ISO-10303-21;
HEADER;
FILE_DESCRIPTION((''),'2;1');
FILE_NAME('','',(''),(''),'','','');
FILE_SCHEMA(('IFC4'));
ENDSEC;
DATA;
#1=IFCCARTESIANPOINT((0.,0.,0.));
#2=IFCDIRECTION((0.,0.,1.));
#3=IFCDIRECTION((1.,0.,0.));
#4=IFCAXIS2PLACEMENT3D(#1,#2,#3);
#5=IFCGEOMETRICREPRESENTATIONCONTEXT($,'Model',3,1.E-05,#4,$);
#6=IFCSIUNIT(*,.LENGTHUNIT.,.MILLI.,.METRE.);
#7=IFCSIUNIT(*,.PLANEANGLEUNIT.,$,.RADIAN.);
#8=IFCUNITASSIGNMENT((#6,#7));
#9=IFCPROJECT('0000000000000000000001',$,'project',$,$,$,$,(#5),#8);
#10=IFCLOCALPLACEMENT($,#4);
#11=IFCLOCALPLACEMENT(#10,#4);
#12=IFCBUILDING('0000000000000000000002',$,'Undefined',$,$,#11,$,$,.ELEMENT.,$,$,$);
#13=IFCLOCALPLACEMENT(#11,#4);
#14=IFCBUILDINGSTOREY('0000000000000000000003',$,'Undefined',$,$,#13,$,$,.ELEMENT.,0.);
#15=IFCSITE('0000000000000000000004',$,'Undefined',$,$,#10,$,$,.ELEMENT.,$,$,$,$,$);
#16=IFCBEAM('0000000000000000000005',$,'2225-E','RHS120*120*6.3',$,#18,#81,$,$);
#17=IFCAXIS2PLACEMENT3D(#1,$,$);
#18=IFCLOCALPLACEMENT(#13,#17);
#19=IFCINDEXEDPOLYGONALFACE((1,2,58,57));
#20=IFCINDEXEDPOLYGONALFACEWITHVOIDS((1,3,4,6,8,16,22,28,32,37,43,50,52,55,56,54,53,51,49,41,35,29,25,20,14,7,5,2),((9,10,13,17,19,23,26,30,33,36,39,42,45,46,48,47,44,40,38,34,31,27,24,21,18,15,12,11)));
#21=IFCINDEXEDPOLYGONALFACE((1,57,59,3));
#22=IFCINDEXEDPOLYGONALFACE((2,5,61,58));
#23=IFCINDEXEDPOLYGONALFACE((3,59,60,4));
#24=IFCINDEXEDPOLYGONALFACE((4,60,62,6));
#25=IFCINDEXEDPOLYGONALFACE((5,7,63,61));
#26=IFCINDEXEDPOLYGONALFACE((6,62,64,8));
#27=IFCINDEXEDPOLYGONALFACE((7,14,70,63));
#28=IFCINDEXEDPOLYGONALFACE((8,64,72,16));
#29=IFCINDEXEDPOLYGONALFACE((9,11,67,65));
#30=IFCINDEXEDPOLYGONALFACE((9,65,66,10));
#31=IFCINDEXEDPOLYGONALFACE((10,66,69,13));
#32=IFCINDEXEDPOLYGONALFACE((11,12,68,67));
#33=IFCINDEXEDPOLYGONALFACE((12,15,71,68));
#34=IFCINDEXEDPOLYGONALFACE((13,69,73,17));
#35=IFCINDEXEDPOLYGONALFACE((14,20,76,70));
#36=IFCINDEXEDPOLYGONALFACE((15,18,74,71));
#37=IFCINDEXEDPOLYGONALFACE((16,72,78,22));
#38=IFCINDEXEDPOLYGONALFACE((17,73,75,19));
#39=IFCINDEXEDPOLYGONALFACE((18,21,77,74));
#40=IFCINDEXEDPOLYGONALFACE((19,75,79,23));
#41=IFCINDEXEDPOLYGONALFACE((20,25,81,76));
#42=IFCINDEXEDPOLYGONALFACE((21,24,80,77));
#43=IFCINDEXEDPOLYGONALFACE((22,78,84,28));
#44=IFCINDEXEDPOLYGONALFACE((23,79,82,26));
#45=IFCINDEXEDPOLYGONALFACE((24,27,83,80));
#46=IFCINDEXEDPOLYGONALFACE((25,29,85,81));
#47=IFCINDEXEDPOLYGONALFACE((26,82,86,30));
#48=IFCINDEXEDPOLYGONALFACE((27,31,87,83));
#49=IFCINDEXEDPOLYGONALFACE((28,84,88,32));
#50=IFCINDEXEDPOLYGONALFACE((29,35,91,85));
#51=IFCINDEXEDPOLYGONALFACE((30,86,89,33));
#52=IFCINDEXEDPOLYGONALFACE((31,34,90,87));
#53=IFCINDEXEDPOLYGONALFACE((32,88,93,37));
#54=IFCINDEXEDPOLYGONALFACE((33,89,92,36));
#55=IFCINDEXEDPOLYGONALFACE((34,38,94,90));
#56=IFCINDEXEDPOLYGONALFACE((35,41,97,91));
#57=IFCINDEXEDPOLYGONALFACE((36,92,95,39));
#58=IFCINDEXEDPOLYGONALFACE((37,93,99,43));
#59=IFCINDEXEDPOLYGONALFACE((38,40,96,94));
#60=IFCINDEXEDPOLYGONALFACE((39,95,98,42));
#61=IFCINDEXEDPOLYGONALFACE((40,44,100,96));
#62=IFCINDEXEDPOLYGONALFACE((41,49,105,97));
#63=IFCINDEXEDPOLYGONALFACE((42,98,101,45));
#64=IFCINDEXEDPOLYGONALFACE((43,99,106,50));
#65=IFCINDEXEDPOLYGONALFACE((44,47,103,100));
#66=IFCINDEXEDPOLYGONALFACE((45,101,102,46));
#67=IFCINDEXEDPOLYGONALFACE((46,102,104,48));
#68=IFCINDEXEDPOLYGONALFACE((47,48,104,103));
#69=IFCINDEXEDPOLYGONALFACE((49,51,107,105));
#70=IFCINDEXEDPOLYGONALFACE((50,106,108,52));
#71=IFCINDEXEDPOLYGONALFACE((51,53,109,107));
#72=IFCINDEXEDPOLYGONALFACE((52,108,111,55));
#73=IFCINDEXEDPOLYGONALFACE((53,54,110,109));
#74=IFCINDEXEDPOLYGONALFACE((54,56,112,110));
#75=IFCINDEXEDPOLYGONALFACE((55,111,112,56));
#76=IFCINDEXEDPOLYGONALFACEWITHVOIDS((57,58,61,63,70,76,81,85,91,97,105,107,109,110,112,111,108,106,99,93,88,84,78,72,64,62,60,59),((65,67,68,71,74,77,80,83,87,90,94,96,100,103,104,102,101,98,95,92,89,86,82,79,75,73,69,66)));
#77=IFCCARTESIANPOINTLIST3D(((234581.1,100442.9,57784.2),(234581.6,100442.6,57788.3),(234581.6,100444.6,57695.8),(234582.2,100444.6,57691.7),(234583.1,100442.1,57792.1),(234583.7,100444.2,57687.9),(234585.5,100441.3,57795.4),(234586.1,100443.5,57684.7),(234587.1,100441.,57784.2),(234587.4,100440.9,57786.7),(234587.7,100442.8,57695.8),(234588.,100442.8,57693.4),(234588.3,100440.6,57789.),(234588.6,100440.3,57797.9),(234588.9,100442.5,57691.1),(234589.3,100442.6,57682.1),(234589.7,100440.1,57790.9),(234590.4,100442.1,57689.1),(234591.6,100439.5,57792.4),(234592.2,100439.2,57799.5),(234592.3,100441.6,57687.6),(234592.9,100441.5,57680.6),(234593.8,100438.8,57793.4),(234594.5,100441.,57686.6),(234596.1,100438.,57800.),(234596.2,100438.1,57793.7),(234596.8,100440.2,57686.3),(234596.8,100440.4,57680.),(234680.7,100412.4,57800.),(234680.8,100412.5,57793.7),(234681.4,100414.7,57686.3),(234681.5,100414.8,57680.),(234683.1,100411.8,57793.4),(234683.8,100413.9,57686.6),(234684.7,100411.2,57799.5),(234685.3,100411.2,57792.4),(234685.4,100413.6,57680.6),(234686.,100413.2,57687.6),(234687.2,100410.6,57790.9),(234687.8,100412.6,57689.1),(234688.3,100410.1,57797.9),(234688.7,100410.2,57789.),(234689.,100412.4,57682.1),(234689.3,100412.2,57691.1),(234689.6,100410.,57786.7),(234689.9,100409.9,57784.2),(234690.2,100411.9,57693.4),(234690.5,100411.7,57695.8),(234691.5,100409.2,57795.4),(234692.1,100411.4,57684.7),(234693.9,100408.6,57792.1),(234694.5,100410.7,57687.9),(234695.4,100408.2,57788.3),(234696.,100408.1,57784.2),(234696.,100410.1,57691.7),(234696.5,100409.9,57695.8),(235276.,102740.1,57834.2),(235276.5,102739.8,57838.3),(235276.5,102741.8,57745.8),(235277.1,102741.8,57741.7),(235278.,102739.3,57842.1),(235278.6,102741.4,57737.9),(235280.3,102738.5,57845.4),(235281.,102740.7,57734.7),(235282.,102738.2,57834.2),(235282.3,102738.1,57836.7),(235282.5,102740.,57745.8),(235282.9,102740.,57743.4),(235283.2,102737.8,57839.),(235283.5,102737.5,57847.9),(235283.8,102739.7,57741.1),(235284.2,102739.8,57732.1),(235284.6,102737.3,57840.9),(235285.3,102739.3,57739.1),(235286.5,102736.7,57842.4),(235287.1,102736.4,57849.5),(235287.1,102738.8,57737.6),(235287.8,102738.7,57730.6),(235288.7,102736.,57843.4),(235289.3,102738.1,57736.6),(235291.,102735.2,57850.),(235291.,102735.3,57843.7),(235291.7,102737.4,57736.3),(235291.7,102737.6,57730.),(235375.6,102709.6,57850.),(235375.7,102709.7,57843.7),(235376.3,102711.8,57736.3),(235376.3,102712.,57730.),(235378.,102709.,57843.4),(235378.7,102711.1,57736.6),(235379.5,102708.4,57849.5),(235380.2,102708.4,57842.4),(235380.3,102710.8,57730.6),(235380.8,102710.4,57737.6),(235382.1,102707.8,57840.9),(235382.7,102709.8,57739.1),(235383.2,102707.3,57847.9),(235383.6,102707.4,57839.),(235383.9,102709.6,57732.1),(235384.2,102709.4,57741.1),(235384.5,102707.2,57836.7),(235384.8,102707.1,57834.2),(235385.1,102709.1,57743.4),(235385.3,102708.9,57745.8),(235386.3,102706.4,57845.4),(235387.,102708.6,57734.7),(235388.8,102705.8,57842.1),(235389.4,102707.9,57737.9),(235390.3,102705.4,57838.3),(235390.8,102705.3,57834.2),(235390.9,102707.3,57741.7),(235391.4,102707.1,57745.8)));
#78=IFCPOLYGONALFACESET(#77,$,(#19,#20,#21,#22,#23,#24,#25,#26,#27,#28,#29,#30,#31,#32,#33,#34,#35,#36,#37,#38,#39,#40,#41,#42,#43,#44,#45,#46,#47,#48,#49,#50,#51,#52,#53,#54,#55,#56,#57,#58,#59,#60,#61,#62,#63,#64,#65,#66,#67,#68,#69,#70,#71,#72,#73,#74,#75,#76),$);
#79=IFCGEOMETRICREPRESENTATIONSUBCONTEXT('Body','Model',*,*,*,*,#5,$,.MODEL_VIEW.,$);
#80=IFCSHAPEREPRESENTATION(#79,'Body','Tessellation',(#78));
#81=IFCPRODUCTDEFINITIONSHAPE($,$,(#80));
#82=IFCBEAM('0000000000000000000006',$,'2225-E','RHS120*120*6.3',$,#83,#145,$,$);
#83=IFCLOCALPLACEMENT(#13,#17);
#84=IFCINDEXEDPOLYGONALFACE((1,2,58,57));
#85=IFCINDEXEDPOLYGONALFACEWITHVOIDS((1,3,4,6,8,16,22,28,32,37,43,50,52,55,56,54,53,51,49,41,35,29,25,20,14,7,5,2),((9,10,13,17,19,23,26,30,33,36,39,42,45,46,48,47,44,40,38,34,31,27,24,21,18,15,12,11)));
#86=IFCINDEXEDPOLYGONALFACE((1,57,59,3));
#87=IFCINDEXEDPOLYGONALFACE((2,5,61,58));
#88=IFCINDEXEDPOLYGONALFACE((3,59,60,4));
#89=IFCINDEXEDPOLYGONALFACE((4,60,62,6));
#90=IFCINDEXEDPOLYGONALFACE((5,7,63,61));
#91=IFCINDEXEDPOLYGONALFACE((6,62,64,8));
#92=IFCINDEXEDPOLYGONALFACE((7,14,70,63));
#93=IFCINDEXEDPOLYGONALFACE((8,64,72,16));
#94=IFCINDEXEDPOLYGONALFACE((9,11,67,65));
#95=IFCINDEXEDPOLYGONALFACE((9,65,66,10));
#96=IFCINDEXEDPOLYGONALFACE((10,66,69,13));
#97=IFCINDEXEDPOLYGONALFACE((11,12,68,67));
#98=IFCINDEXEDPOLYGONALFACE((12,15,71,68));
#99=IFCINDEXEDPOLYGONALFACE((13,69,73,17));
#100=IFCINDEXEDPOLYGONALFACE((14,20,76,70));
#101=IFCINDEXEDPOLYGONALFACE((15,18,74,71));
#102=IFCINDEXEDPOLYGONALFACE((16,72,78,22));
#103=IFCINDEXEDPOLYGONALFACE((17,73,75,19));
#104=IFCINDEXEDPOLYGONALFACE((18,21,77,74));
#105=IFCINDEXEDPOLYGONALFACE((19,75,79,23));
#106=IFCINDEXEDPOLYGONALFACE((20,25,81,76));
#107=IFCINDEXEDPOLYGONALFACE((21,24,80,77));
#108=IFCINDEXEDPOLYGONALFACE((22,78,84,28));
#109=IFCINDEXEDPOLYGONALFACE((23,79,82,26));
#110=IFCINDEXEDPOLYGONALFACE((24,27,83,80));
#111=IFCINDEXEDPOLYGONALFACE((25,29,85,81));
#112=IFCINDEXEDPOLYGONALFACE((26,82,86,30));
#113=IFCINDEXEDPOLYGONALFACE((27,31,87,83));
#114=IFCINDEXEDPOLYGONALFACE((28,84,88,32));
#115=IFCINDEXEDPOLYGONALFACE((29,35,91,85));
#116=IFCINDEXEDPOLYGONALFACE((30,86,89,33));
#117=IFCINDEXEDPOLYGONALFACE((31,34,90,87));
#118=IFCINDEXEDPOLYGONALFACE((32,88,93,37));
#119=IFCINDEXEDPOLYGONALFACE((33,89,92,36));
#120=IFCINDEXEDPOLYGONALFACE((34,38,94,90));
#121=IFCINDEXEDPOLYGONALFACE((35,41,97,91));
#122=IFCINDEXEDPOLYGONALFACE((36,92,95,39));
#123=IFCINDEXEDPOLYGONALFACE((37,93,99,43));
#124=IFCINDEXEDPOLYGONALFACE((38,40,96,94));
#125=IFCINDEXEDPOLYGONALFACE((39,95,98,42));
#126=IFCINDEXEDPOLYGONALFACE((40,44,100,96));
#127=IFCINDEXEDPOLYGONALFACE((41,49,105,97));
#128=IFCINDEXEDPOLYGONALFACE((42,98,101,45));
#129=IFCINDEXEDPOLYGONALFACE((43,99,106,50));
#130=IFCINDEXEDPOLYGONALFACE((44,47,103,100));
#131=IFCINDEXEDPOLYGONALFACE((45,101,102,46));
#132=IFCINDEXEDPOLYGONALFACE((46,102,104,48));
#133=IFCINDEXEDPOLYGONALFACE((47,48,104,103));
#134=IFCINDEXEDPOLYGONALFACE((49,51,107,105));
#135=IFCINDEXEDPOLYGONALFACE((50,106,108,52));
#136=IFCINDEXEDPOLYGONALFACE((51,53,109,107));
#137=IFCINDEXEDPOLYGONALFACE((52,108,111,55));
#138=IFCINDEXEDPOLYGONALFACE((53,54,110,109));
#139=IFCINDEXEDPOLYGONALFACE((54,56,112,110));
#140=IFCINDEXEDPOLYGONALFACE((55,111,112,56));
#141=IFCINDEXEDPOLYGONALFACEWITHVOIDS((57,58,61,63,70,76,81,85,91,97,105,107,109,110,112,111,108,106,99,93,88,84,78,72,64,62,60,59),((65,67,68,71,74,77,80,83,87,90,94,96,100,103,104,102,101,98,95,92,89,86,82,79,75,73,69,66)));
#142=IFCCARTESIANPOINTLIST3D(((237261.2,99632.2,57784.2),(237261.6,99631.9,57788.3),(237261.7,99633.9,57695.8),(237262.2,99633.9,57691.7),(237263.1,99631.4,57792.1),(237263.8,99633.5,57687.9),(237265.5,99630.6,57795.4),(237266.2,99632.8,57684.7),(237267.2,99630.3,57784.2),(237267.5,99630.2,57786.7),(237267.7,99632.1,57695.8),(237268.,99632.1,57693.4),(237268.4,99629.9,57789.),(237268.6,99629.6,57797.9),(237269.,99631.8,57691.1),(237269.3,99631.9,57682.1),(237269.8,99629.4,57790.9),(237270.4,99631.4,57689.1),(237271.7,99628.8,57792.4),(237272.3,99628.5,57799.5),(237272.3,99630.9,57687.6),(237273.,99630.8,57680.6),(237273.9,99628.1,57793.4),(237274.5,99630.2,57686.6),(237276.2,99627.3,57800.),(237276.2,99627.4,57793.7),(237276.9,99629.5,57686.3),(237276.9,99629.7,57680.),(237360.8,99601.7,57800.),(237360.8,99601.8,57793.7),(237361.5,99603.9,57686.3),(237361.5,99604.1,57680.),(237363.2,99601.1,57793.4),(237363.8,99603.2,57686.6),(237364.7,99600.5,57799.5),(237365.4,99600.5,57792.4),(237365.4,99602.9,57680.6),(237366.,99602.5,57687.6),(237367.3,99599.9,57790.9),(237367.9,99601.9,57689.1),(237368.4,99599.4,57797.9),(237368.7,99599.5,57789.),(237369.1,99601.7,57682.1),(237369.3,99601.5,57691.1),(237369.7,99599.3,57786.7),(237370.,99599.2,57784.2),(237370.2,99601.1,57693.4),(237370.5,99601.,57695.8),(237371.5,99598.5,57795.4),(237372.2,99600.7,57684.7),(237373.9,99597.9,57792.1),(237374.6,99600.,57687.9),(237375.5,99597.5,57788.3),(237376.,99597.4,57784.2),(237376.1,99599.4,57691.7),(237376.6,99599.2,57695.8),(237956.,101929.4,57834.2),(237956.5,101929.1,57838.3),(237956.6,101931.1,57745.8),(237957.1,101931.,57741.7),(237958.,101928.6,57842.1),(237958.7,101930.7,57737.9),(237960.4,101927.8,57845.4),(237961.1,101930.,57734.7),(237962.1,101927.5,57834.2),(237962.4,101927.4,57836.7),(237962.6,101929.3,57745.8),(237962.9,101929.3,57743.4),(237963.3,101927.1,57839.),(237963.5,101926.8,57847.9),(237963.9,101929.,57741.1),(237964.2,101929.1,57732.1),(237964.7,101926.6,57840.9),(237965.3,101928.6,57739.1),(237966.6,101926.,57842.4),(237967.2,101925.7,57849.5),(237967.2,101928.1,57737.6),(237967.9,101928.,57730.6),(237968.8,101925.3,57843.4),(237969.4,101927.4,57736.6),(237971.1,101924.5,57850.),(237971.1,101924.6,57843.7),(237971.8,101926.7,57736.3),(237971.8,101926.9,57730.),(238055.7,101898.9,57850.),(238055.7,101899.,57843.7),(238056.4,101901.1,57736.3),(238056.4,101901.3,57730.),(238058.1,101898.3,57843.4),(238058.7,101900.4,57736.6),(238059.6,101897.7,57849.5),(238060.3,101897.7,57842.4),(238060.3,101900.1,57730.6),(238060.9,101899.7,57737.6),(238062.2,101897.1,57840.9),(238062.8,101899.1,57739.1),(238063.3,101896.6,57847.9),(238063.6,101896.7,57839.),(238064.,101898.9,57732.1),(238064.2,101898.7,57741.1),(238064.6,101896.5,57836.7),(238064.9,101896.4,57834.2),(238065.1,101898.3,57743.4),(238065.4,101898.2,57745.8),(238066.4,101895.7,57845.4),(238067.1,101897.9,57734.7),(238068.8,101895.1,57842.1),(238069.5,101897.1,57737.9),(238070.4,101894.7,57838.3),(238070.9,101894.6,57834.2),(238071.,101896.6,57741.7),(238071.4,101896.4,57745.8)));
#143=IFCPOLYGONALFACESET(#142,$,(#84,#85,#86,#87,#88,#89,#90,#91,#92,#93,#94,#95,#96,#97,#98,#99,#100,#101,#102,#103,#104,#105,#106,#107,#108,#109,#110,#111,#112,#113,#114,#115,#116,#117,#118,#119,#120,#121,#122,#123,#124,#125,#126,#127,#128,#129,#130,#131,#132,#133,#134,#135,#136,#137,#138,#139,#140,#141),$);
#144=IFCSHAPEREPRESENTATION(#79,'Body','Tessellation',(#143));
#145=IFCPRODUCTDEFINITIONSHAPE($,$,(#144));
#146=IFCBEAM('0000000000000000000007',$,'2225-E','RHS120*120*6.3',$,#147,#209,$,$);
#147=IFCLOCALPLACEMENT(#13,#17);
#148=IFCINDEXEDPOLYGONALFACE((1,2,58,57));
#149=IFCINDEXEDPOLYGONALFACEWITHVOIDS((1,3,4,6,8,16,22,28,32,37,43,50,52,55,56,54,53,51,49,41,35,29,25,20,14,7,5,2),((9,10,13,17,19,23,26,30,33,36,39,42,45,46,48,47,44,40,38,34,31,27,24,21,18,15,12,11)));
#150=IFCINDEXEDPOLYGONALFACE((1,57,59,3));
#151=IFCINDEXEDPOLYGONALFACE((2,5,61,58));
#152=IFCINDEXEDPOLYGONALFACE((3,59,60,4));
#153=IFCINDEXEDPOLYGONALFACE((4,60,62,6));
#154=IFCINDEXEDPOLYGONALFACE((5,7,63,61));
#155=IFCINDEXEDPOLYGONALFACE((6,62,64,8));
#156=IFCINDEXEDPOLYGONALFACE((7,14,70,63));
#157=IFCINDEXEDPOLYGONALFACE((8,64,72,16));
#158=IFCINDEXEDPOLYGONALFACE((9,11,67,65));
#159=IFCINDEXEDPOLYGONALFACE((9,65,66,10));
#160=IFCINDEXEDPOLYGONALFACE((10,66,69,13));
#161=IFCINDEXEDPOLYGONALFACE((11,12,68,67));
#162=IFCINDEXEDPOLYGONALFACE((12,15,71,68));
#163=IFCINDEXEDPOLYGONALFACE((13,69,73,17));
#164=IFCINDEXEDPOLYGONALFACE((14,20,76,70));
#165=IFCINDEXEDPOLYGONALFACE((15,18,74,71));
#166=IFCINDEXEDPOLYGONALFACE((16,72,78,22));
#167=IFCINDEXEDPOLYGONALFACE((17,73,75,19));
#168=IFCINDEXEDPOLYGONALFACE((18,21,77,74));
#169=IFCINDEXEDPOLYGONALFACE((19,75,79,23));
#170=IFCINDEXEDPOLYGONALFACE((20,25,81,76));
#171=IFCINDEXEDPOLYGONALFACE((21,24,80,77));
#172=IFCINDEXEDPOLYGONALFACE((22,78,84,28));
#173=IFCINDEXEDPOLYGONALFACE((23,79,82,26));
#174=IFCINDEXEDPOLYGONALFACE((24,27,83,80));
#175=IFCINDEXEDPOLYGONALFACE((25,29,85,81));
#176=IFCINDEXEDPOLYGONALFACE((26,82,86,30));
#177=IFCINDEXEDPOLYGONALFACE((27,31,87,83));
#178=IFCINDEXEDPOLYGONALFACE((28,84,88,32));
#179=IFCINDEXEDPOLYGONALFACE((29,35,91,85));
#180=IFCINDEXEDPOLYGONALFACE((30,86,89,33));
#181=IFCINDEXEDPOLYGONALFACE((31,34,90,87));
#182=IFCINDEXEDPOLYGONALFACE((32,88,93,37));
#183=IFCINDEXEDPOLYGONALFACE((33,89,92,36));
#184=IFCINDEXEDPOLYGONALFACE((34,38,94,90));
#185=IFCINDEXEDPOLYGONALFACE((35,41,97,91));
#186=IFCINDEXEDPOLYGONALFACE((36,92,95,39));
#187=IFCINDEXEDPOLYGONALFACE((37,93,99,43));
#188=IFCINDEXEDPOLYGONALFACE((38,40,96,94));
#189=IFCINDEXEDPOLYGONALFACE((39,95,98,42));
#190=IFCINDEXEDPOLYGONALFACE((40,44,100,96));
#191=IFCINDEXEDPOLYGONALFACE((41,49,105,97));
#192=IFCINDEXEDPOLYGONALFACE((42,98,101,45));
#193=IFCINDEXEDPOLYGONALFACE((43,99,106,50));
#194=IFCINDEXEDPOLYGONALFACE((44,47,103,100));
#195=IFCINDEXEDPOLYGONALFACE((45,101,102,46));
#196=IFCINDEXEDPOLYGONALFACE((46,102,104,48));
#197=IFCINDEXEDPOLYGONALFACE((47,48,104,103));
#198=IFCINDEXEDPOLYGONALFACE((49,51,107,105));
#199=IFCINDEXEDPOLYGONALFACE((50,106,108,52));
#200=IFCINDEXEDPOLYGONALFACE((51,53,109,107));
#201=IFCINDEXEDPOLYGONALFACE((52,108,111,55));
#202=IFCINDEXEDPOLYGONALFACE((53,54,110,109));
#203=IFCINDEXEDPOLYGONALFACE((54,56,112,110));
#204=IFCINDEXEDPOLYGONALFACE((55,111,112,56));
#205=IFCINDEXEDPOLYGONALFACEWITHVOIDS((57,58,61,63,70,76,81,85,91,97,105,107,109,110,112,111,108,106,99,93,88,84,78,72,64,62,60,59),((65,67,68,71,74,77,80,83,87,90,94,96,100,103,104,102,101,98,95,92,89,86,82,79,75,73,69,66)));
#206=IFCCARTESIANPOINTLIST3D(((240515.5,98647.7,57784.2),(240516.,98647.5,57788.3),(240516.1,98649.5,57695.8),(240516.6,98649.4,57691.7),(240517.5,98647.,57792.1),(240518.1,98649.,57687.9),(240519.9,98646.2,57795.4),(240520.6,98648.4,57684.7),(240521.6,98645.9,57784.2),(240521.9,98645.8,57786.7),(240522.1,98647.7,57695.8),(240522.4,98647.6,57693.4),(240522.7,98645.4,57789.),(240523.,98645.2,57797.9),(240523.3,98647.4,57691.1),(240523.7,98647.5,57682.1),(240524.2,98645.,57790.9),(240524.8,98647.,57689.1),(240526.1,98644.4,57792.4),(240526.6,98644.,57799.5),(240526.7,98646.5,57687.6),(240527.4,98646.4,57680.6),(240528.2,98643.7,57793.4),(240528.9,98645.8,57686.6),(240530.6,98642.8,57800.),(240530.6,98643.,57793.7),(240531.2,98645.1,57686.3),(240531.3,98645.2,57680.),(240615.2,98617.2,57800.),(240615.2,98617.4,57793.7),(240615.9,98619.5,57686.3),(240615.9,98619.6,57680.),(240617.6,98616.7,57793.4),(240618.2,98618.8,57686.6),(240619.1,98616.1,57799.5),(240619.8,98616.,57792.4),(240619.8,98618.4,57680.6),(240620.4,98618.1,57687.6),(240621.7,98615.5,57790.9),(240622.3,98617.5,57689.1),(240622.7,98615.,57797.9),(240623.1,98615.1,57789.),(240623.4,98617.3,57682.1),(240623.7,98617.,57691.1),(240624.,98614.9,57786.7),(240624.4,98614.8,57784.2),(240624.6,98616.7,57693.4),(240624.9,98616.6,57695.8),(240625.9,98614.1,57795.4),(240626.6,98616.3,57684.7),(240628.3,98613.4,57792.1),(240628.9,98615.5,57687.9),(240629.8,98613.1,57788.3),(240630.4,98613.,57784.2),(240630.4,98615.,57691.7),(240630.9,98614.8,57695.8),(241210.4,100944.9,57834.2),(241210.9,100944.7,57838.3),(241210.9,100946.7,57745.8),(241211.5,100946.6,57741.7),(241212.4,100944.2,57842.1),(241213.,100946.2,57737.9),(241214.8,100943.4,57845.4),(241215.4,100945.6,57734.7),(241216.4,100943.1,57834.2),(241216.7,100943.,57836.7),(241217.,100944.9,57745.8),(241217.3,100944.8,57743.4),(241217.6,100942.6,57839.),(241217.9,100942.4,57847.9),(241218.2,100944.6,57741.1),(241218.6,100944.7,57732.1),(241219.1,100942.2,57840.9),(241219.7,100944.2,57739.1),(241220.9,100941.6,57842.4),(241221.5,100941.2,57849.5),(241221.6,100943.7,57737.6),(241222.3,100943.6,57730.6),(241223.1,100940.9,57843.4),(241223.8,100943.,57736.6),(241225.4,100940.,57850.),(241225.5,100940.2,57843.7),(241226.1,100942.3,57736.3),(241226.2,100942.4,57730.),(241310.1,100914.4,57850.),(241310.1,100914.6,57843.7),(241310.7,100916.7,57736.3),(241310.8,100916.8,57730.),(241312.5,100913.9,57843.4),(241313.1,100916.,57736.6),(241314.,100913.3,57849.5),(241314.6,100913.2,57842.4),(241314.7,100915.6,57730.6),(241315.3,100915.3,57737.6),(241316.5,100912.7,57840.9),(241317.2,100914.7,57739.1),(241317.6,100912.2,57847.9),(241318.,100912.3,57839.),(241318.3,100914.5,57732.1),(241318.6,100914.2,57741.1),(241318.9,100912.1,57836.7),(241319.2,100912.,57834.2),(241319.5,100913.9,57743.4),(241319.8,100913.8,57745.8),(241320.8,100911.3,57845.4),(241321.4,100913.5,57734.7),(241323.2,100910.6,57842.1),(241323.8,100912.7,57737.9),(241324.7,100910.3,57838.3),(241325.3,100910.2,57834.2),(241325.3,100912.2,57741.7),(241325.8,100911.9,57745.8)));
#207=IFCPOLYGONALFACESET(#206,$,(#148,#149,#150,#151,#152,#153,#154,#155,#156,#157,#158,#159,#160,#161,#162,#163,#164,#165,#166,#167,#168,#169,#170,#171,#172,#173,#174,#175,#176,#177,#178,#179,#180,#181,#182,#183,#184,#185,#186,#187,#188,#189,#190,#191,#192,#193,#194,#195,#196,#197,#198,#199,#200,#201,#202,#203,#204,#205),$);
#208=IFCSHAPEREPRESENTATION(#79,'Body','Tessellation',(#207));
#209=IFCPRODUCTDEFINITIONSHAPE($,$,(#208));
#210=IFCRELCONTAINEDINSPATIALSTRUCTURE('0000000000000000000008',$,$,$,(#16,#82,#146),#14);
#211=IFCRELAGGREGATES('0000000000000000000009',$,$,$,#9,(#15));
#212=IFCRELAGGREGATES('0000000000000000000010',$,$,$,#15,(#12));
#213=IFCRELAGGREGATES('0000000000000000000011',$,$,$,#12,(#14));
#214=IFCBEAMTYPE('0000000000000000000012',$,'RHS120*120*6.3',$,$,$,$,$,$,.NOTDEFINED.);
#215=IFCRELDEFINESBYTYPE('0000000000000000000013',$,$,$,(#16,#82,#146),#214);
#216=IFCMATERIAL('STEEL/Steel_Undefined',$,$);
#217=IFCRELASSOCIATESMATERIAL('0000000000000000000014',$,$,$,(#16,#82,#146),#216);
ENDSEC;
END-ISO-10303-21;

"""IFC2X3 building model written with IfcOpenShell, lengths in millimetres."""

from ifc_helpers import new_model, si_unit, frame, origin_with_axes, origin_2d_with_axis, place, context, subcontext, project, spatial, hollow_rectangle, extrude, material, type_object, element, save


model = new_model("IFC2X3")

# Units and contexts
model_context = context("Model", 3, precision=1e-05, world=origin_with_axes())
body_context = subcontext(model_context, "Body", "Model", "MODEL_VIEW")
ifc_project = project(units=[si_unit("LENGTHUNIT", "METRE", prefix="MILLI"), si_unit("PLANEANGLEUNIT", "RADIAN")], contexts=[model_context])

# Site, building, storey
site_placement = place(None, origin_with_axes())
site = spatial("IfcSite", under=ifc_project, at=site_placement, Name="Undefined", CompositionType="ELEMENT")
building_placement = place(site_placement, origin_with_axes())
building = spatial("IfcBuilding", under=site, at=building_placement, Name="Undefined", CompositionType="ELEMENT")
storey_placement = place(building_placement, origin_with_axes())
storey = spatial("IfcBuildingStorey", under=building, at=storey_placement, Name="Undefined", CompositionType="ELEMENT", Elevation=0.0)

# Shared definitions
ifc_material_1 = material(Name="STEEL/Steel_Undefined")

# Beams
beam_type_1 = type_object("IfcBeamType", Name="RHS120*120*6.3", PredefinedType="NOTDEFINED")
for number, where, z_axis, x_axis, name in (
    (1, (234638.8, 100426.4, 57740.0), (-0.006031, -0.019937, 0.999783), (0.289475, 0.956959, 0.020829), "2225-E"),
    (2, (237318.9, 99615.7, 57740.0), (-0.006031, -0.019937, 0.999783), (0.289475, 0.956959, 0.020829), "2225-E"),
    (3, (240573.2, 98631.2, 57740.0), (-0.006031, -0.019937, 0.999783), (0.289475, 0.956959, 0.020829), "2225-E"),
):
    element("IfcBeam", number, at=place(storey_placement, frame(where, z_axis=z_axis, x_axis=x_axis)), inside=storey, type_object=beam_type_1, material=ifc_material_1, Name=name, Description="RHS120*120*6.3", context=body_context, shape_type="SweptSolid", body=[
        extrude(hollow_rectangle(XDim=120.0, YDim=120.0, WallThickness=6.3, InnerFilletRadius=9.5, OuterFilletRadius=15.8, at=origin_2d_with_axis()), frame((2400.5, 0.0, 0.0), z_axis=(-1.0, 0.0, 0.0), x_axis=(0.0, -1.0, 0.0)), (0.0, 0.0, 1.0), 2400.5),
    ])

save(model, "model.ifc")
